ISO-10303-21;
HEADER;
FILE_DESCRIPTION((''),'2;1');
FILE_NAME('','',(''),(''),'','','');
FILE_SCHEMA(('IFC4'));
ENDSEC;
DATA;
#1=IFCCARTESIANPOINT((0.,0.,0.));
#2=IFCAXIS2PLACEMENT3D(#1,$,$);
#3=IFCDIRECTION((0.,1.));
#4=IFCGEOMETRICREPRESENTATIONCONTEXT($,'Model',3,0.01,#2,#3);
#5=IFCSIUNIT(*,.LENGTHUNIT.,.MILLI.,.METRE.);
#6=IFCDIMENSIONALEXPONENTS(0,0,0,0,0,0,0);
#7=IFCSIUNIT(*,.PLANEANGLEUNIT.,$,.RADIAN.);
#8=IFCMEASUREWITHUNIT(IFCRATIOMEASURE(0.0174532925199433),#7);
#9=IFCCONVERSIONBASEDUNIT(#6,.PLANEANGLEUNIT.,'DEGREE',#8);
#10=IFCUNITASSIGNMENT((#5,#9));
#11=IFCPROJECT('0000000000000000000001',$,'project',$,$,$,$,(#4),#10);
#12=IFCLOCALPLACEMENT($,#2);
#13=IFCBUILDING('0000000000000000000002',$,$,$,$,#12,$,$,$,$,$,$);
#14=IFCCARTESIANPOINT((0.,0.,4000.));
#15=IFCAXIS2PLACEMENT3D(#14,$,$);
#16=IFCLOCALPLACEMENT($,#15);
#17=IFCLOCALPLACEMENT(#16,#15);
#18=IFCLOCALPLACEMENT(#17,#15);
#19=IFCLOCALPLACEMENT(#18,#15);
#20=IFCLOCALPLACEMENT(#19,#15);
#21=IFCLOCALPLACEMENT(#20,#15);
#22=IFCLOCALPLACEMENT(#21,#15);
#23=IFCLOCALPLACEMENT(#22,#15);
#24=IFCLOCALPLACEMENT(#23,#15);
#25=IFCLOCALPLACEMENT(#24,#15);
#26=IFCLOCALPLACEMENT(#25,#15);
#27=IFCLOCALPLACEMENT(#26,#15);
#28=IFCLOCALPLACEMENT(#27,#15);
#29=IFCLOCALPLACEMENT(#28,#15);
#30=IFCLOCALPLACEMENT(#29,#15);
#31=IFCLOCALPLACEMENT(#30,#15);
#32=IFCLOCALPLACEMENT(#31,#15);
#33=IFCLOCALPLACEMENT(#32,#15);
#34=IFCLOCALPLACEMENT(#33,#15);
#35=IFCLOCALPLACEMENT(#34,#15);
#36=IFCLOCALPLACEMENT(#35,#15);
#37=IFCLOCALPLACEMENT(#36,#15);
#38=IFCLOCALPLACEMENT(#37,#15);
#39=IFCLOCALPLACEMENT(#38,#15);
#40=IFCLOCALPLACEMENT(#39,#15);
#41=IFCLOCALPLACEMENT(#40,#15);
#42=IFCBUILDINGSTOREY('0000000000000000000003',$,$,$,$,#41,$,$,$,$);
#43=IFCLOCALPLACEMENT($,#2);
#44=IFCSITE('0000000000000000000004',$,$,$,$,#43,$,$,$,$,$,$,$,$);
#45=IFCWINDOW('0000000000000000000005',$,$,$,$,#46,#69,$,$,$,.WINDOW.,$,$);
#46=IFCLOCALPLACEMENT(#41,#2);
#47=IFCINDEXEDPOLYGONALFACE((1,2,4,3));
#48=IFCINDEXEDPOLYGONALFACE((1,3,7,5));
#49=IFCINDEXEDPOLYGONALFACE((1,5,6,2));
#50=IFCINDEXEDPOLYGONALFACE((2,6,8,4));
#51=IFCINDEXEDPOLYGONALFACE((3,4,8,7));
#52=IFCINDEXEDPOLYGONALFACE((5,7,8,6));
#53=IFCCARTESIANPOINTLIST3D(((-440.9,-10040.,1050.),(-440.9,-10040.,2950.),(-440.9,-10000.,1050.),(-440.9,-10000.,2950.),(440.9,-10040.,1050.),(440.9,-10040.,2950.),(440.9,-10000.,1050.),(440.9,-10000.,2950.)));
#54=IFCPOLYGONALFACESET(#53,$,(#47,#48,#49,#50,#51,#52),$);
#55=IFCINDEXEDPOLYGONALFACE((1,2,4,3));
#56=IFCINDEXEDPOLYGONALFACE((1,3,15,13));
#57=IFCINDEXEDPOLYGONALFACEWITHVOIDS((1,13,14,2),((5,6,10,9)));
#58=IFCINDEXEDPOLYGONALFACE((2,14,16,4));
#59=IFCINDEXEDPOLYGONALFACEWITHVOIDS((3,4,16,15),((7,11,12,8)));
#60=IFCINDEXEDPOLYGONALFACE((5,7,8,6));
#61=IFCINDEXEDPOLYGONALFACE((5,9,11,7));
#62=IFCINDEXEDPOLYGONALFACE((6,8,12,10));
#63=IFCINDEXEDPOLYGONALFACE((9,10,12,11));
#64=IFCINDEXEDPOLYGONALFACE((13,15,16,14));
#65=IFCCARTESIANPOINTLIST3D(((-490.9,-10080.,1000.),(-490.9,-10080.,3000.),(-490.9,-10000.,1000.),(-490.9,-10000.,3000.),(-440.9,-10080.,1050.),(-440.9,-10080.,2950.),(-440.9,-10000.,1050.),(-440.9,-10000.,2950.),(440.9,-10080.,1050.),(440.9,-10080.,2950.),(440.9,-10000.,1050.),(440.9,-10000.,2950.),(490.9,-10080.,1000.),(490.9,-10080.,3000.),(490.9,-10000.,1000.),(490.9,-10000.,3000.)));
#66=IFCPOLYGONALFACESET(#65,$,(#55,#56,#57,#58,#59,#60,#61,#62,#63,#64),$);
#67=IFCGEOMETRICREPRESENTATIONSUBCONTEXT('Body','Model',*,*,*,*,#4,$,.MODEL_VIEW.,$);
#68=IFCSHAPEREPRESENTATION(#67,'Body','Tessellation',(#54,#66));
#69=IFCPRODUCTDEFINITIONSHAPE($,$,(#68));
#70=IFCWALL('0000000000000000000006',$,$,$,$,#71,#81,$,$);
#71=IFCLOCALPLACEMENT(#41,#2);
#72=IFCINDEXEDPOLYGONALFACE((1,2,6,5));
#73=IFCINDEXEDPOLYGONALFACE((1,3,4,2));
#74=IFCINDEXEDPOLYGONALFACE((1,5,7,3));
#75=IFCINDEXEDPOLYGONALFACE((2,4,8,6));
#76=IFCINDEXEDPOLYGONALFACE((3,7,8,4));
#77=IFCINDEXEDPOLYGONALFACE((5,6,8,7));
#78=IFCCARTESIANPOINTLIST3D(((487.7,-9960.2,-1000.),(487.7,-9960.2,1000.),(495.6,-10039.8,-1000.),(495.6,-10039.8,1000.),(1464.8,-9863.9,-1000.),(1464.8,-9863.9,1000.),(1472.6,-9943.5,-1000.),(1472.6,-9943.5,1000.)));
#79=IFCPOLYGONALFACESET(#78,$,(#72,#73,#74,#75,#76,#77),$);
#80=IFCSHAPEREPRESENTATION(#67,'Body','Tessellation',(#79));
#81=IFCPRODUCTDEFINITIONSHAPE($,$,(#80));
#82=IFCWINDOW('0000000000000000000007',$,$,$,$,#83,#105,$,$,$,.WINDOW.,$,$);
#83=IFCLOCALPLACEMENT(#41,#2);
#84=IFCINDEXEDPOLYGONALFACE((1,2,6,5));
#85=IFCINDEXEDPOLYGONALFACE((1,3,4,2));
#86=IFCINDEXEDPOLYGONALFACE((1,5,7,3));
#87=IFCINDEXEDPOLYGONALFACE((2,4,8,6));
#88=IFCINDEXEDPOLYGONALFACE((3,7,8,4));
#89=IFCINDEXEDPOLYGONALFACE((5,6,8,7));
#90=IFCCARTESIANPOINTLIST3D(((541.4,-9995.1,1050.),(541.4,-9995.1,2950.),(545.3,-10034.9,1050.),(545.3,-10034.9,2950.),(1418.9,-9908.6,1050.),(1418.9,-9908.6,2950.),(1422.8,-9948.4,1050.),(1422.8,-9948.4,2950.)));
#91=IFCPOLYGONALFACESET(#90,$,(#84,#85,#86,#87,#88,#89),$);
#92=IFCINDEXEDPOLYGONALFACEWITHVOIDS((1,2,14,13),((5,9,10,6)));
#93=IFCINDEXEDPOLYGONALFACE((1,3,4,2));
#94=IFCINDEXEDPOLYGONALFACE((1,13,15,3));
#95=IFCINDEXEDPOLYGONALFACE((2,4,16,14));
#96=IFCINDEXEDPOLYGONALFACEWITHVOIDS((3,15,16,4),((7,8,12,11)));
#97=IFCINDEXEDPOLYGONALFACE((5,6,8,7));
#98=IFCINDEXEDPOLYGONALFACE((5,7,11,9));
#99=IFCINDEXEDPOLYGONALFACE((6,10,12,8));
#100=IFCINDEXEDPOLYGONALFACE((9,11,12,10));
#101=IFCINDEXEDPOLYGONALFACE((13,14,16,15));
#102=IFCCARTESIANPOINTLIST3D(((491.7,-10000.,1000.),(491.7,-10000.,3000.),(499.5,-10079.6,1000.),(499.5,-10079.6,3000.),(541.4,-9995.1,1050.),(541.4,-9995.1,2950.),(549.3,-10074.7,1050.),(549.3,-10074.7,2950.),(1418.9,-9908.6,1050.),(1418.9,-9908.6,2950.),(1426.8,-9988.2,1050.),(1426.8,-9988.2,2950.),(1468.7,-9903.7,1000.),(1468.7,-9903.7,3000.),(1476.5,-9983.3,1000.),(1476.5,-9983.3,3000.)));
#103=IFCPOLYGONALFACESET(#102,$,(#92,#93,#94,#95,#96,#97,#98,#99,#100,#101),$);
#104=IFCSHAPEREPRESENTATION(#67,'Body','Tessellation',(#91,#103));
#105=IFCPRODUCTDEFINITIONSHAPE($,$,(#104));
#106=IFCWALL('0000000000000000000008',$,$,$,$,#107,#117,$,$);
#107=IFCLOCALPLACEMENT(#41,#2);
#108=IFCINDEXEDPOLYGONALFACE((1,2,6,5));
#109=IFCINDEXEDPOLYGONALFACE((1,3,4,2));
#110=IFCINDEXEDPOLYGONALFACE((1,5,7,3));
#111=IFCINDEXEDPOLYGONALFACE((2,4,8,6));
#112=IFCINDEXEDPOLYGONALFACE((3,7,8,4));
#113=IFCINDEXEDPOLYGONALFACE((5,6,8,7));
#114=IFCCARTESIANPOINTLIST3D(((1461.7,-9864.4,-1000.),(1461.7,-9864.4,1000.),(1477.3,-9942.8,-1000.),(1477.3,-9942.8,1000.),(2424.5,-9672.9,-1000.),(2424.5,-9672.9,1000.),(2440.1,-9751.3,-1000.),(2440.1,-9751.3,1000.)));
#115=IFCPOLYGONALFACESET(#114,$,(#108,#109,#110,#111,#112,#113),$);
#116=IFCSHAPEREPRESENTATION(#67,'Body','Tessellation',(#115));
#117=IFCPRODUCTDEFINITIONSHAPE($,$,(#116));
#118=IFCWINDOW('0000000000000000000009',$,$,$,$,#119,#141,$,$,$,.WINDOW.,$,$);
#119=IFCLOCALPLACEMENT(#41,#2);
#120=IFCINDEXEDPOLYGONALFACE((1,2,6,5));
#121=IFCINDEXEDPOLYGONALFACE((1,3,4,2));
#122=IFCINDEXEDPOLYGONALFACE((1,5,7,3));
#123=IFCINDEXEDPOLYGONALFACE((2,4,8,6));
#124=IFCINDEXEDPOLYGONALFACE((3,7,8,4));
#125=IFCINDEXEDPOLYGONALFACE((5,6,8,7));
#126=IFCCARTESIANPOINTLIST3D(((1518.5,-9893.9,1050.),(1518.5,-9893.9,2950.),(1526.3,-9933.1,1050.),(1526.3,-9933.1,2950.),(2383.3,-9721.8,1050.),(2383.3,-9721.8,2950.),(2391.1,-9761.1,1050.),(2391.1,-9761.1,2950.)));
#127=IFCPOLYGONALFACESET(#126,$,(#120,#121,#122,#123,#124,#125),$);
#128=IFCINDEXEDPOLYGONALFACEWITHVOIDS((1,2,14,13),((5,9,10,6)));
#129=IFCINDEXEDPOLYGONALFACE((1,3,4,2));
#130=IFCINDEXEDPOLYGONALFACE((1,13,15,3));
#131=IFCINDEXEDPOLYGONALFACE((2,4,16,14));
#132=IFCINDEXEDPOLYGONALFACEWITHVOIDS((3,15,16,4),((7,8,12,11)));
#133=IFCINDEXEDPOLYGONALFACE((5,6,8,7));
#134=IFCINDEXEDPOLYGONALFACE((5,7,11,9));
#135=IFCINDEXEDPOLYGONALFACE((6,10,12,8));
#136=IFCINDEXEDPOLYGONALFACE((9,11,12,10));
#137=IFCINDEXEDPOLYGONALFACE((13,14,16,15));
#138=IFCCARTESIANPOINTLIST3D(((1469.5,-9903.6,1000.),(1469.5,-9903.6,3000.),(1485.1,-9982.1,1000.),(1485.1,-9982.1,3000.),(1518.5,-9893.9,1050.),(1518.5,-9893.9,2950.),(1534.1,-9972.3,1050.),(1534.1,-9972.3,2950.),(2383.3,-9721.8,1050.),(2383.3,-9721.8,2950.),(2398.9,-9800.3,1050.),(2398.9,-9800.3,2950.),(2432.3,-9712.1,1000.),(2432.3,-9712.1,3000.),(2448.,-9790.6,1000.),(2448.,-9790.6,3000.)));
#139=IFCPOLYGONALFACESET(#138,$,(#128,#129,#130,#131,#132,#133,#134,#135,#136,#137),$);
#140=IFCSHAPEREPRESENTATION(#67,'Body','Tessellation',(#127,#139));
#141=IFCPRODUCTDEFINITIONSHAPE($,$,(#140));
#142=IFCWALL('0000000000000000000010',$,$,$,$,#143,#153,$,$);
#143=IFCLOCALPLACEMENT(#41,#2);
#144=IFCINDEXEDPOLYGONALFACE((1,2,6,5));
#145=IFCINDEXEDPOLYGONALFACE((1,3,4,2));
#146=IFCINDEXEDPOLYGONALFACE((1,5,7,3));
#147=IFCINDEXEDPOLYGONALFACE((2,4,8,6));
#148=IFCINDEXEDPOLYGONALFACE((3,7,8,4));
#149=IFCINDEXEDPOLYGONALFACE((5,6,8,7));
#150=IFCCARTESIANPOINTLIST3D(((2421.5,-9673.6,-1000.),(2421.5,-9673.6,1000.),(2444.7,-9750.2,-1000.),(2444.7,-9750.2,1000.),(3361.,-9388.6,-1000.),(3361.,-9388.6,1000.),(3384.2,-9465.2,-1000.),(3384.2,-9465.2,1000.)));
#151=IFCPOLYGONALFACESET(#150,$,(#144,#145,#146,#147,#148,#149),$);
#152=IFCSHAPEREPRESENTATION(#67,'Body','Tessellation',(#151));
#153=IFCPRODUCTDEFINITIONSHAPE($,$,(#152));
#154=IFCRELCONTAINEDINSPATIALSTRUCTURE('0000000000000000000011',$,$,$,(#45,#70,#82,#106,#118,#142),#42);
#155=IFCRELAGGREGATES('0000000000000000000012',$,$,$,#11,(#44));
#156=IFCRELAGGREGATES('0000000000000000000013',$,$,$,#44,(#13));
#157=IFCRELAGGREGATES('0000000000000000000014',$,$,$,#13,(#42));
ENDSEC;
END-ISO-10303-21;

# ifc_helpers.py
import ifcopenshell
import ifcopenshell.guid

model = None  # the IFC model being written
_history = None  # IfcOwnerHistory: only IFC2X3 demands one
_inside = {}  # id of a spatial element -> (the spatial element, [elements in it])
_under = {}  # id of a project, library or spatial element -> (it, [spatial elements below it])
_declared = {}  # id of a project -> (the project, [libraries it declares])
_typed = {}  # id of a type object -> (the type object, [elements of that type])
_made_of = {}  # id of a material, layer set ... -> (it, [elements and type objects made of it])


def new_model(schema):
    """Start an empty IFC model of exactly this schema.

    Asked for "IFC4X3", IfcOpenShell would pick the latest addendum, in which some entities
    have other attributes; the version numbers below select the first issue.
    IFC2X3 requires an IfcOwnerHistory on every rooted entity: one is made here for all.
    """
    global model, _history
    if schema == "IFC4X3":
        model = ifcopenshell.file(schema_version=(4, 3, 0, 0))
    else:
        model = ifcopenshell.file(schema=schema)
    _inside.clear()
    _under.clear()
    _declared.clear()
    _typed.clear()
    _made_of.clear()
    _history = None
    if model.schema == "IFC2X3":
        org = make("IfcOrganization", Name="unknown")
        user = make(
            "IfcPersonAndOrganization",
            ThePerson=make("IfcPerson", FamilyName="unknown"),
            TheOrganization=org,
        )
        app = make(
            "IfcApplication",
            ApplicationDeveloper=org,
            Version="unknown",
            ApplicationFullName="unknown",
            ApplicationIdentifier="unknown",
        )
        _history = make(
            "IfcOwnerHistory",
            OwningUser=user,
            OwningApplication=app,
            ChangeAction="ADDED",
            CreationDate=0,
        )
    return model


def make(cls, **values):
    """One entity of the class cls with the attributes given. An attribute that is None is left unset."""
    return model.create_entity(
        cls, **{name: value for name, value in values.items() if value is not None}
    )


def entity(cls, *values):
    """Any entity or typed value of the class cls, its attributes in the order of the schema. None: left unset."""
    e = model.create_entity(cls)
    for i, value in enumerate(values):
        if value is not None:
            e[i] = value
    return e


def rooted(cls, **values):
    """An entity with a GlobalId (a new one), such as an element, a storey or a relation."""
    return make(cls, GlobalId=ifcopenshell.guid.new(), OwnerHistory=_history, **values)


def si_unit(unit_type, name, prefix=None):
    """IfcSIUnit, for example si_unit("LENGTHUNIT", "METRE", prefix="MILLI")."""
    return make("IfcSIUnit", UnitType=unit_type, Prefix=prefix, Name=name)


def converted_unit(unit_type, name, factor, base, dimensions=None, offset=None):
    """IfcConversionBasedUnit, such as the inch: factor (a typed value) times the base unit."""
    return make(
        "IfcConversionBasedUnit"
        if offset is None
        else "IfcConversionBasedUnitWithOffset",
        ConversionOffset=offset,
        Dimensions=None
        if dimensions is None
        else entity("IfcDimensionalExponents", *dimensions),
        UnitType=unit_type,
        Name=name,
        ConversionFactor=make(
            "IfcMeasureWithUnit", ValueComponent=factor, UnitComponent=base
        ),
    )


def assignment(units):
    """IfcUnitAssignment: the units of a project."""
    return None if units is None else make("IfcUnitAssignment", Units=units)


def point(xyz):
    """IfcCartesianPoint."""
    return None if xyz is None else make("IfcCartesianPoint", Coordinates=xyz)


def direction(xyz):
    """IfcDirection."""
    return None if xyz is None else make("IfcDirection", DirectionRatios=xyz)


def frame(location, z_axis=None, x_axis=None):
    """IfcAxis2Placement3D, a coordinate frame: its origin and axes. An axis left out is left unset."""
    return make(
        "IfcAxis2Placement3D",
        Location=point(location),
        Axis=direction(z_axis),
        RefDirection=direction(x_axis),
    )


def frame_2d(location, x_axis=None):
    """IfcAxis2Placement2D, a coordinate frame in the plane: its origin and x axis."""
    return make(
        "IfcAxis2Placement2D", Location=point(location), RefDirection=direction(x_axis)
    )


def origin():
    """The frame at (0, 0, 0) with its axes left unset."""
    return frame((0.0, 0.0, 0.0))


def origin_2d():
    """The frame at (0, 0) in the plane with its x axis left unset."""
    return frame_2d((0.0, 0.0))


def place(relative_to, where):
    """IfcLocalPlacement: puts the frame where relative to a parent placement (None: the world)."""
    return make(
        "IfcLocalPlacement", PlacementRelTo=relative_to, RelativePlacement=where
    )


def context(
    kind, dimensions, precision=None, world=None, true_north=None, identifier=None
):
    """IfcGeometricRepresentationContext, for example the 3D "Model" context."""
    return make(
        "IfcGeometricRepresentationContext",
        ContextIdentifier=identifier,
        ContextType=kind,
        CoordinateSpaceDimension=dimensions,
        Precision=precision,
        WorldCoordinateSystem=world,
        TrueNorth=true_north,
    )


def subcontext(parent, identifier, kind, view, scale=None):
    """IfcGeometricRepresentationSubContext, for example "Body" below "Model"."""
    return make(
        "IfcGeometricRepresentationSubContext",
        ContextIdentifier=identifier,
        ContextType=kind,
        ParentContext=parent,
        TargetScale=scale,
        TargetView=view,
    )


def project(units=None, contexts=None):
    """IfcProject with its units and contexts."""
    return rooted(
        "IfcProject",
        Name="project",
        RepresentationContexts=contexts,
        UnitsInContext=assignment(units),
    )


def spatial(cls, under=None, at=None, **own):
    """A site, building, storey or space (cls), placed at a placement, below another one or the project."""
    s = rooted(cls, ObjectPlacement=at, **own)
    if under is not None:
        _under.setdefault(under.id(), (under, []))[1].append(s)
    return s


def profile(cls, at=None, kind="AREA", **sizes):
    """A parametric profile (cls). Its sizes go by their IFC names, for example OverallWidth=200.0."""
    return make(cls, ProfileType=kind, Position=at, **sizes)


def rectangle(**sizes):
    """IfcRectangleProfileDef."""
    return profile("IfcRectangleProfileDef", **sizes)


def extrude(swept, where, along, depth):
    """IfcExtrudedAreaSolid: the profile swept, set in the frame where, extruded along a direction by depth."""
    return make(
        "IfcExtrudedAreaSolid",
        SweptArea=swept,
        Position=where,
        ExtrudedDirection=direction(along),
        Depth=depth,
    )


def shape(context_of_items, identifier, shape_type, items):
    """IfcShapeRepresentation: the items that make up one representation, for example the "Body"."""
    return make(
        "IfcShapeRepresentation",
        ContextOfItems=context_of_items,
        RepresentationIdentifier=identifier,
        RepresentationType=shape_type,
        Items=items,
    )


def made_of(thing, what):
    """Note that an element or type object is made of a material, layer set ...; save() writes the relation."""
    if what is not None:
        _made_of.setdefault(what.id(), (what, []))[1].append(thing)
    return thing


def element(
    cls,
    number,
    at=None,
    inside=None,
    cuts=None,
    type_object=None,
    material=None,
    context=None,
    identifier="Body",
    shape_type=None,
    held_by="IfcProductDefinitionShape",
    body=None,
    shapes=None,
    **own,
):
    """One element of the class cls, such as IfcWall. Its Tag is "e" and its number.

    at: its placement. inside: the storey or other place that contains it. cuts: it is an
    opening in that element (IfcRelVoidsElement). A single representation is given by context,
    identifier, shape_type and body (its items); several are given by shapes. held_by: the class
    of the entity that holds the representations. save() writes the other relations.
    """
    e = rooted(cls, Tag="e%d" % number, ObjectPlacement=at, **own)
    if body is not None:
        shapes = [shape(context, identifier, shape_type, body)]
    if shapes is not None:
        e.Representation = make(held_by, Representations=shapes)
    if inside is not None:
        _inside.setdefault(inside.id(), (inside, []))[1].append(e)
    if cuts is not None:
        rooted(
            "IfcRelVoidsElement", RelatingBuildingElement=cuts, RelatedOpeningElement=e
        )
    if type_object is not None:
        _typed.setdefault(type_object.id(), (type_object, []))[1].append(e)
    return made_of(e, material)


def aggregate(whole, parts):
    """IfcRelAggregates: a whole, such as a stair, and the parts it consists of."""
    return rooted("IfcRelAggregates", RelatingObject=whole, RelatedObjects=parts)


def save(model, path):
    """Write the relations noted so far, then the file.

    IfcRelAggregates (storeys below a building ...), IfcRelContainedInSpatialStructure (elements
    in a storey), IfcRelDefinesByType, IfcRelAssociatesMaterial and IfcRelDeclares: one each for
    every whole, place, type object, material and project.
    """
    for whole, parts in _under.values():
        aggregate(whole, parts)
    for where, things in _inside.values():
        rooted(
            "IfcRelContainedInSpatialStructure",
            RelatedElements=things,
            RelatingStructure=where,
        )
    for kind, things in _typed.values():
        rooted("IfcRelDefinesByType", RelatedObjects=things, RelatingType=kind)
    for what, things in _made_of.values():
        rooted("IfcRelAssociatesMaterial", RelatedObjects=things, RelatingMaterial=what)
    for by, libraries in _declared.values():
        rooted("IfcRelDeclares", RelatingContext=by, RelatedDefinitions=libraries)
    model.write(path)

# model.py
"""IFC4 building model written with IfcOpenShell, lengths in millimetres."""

from ifc_helpers import new_model, entity, si_unit, converted_unit, direction, frame, origin, origin_2d, place, context, subcontext, project, spatial, rectangle, extrude, element, save


model = new_model("IFC4")

# Units and contexts
model_context = context("Model", 3, precision=0.01, world=origin(), true_north=direction((0.0, 1.0)))
body_context = subcontext(model_context, "Body", "Model", "MODEL_VIEW")
ifc_project = project(units=[si_unit("LENGTHUNIT", "METRE", prefix="MILLI"), converted_unit("PLANEANGLEUNIT", "DEGREE", entity("IfcRatioMeasure", 0.0174532925199433), si_unit("PLANEANGLEUNIT", "RADIAN"), dimensions=[0, 0, 0, 0, 0, 0, 0])], contexts=[model_context])

# Site, building, storey
site_placement = place(None, origin())
site = spatial("IfcSite", under=ifc_project, at=site_placement)
building_placement = place(None, origin())
building = spatial("IfcBuilding", under=site, at=building_placement)
placement_1 = place(None, frame((0.0, 0.0, 4000.0)))
placement_2 = place(placement_1, frame((0.0, 0.0, 4000.0)))
placement_3 = place(placement_2, frame((0.0, 0.0, 4000.0)))
placement_4 = place(placement_3, frame((0.0, 0.0, 4000.0)))
placement_5 = place(placement_4, frame((0.0, 0.0, 4000.0)))
placement_6 = place(placement_5, frame((0.0, 0.0, 4000.0)))
placement_7 = place(placement_6, frame((0.0, 0.0, 4000.0)))
placement_8 = place(placement_7, frame((0.0, 0.0, 4000.0)))
placement_9 = place(placement_8, frame((0.0, 0.0, 4000.0)))
placement_10 = place(placement_9, frame((0.0, 0.0, 4000.0)))
placement_11 = place(placement_10, frame((0.0, 0.0, 4000.0)))
placement_12 = place(placement_11, frame((0.0, 0.0, 4000.0)))
placement_13 = place(placement_12, frame((0.0, 0.0, 4000.0)))
placement_14 = place(placement_13, frame((0.0, 0.0, 4000.0)))
placement_15 = place(placement_14, frame((0.0, 0.0, 4000.0)))
placement_16 = place(placement_15, frame((0.0, 0.0, 4000.0)))
placement_17 = place(placement_16, frame((0.0, 0.0, 4000.0)))
placement_18 = place(placement_17, frame((0.0, 0.0, 4000.0)))
placement_19 = place(placement_18, frame((0.0, 0.0, 4000.0)))
placement_20 = place(placement_19, frame((0.0, 0.0, 4000.0)))
placement_21 = place(placement_20, frame((0.0, 0.0, 4000.0)))
placement_22 = place(placement_21, frame((0.0, 0.0, 4000.0)))
placement_23 = place(placement_22, frame((0.0, 0.0, 4000.0)))
placement_24 = place(placement_23, frame((0.0, 0.0, 4000.0)))
placement_25 = place(placement_24, frame((0.0, 0.0, 4000.0)))
storey_placement = place(placement_25, frame((0.0, 0.0, 4000.0)))
storey = spatial("IfcBuildingStorey", under=building, at=storey_placement)

# Window
cartesian_point_1 = entity("IfcCartesianPoint", [-440.9, -950.0])
shared_polyline = entity("IfcPolyline", [cartesian_point_1, entity("IfcCartesianPoint", [-440.9, 950.0]), entity("IfcCartesianPoint", [-440.9, 950.0]), entity("IfcCartesianPoint", [440.9, 950.0]), entity("IfcCartesianPoint", [440.9, 950.0]), entity("IfcCartesianPoint", [440.9, -950.0]), entity("IfcCartesianPoint", [440.9, -950.0]), entity("IfcCartesianPoint", [-440.9, -950.0]), cartesian_point_1])
window_1_placement = place(storey_placement, frame((0.0, -10000.0, 2000.0), z_axis=(0.0, 0.0, 1.0), x_axis=(10000.0, 0.000119, 0.0)))
cartesian_point_2 = entity("IfcCartesianPoint", [-490.9, -1000.0])
element("IfcWindow", 1, at=window_1_placement, inside=storey, PredefinedType="WINDOW", context=body_context, shape_type="SweptSolid", body=[
    entity("IfcExtrudedAreaSolid", entity("IfcArbitraryClosedProfileDef", "AREA", None, shared_polyline), entity("IfcAxis2Placement3D", entity("IfcCartesianPoint", [0.0, 0.0, 0.0]), entity("IfcDirection", [0.0, -1.0, 0.0]), entity("IfcDirection", [1.0, 0.0, 0.0])), entity("IfcDirection", [0.0, 0.0, 1.0]), 40.0),
    entity("IfcExtrudedAreaSolid", entity("IfcArbitraryProfileDefWithVoids", "AREA", None, entity("IfcPolyline", [cartesian_point_2, entity("IfcCartesianPoint", [-490.9, 1000.0]), entity("IfcCartesianPoint", [-490.9, 1000.0]), entity("IfcCartesianPoint", [490.9, 1000.0]), entity("IfcCartesianPoint", [490.9, 1000.0]), entity("IfcCartesianPoint", [490.9, -1000.0]), entity("IfcCartesianPoint", [490.9, -1000.0]), entity("IfcCartesianPoint", [-490.9, -1000.0]), cartesian_point_2]), [shared_polyline]), entity("IfcAxis2Placement3D", entity("IfcCartesianPoint", [0.0, 0.0, 0.0]), entity("IfcDirection", [0.0, -1.0, 0.0]), entity("IfcDirection", [1.0, 0.0, 0.0])), entity("IfcDirection", [0.0, 0.0, 1.0]), 80.0),
])

# Wall
wall_1_placement = place(storey_placement, frame((980.2, -9951.8, -1000.0), z_axis=(0.0, 0.0, 1.0), x_axis=(9951.84745, 980.169547, 0.0)))
element("IfcWall", 2, at=wall_1_placement, inside=storey, context=body_context, shape_type="SweptSolid", body=[
    extrude(rectangle(XDim=981.7, YDim=80.0, at=origin_2d()), origin(), (0.0, 0.0, 1.0), 2000.0),
])

# Window
window_2_placement = place(storey_placement, frame((980.2, -9951.8, 2000.0), z_axis=(0.0, 0.0, 1.0), x_axis=(9951.84745, 980.169547, 0.0)))
cartesian_point_3 = entity("IfcCartesianPoint", [-490.9, -1000.0])
element("IfcWindow", 3, at=window_2_placement, inside=storey, PredefinedType="WINDOW", context=body_context, shape_type="SweptSolid", body=[
    entity("IfcExtrudedAreaSolid", entity("IfcArbitraryClosedProfileDef", "AREA", None, shared_polyline), entity("IfcAxis2Placement3D", entity("IfcCartesianPoint", [0.0, 0.0, 0.0]), entity("IfcDirection", [0.0, -1.0, 0.0]), entity("IfcDirection", [1.0, 0.0, 0.0])), entity("IfcDirection", [0.0, 0.0, 1.0]), 40.0),
    entity("IfcExtrudedAreaSolid", entity("IfcArbitraryProfileDefWithVoids", "AREA", None, entity("IfcPolyline", [cartesian_point_3, entity("IfcCartesianPoint", [-490.9, 1000.0]), entity("IfcCartesianPoint", [-490.9, 1000.0]), entity("IfcCartesianPoint", [490.9, 1000.0]), entity("IfcCartesianPoint", [490.9, 1000.0]), entity("IfcCartesianPoint", [490.9, -1000.0]), entity("IfcCartesianPoint", [490.9, -1000.0]), entity("IfcCartesianPoint", [-490.9, -1000.0]), cartesian_point_3]), [shared_polyline]), entity("IfcAxis2Placement3D", entity("IfcCartesianPoint", [0.0, 0.0, 0.0]), entity("IfcDirection", [0.0, -1.0, 0.0]), entity("IfcDirection", [1.0, 0.0, 0.0])), entity("IfcDirection", [0.0, 0.0, 1.0]), 80.0),
])

# Wall
wall_2_placement = place(storey_placement, frame((1950.9, -9807.9, -1000.0), z_axis=(0.0, 0.0, 1.0), x_axis=(9807.852625, 1950.904121, 0.0)))
element("IfcWall", 4, at=wall_2_placement, inside=storey, context=body_context, shape_type="SweptSolid", body=[
    extrude(rectangle(XDim=981.7, YDim=80.0, at=origin_2d()), origin(), (0.0, 0.0, 1.0), 2000.0),
])

# Window
window_3_placement = place(storey_placement, frame((1950.9, -9807.9, 2000.0), z_axis=(0.0, 0.0, 1.0), x_axis=(9807.852625, 1950.904121, 0.0)))
cartesian_point_4 = entity("IfcCartesianPoint", [-490.9, -1000.0])
element("IfcWindow", 5, at=window_3_placement, inside=storey, PredefinedType="WINDOW", context=body_context, shape_type="SweptSolid", body=[
    entity("IfcExtrudedAreaSolid", entity("IfcArbitraryClosedProfileDef", "AREA", None, shared_polyline), entity("IfcAxis2Placement3D", entity("IfcCartesianPoint", [0.0, 0.0, 0.0]), entity("IfcDirection", [0.0, -1.0, 0.0]), entity("IfcDirection", [1.0, 0.0, 0.0])), entity("IfcDirection", [0.0, 0.0, 1.0]), 40.0),
    entity("IfcExtrudedAreaSolid", entity("IfcArbitraryProfileDefWithVoids", "AREA", None, entity("IfcPolyline", [cartesian_point_4, entity("IfcCartesianPoint", [-490.9, 1000.0]), entity("IfcCartesianPoint", [-490.9, 1000.0]), entity("IfcCartesianPoint", [490.9, 1000.0]), entity("IfcCartesianPoint", [490.9, 1000.0]), entity("IfcCartesianPoint", [490.9, -1000.0]), entity("IfcCartesianPoint", [490.9, -1000.0]), entity("IfcCartesianPoint", [-490.9, -1000.0]), cartesian_point_4]), [shared_polyline]), entity("IfcAxis2Placement3D", entity("IfcCartesianPoint", [0.0, 0.0, 0.0]), entity("IfcDirection", [0.0, -1.0, 0.0]), entity("IfcDirection", [1.0, 0.0, 0.0])), entity("IfcDirection", [0.0, 0.0, 1.0]), 80.0),
])

# Wall
wall_3_placement = place(storey_placement, frame((2902.8, -9569.4, -1000.0), z_axis=(0.0, 0.0, 1.0), x_axis=(9569.403667, 2902.845753, 0.0)))
element("IfcWall", 6, at=wall_3_placement, inside=storey, context=body_context, shape_type="SweptSolid", body=[
    extrude(rectangle(XDim=981.7, YDim=80.0, at=origin_2d()), origin(), (0.0, 0.0, 1.0), 2000.0),
])

save(model, "model.ifc")
